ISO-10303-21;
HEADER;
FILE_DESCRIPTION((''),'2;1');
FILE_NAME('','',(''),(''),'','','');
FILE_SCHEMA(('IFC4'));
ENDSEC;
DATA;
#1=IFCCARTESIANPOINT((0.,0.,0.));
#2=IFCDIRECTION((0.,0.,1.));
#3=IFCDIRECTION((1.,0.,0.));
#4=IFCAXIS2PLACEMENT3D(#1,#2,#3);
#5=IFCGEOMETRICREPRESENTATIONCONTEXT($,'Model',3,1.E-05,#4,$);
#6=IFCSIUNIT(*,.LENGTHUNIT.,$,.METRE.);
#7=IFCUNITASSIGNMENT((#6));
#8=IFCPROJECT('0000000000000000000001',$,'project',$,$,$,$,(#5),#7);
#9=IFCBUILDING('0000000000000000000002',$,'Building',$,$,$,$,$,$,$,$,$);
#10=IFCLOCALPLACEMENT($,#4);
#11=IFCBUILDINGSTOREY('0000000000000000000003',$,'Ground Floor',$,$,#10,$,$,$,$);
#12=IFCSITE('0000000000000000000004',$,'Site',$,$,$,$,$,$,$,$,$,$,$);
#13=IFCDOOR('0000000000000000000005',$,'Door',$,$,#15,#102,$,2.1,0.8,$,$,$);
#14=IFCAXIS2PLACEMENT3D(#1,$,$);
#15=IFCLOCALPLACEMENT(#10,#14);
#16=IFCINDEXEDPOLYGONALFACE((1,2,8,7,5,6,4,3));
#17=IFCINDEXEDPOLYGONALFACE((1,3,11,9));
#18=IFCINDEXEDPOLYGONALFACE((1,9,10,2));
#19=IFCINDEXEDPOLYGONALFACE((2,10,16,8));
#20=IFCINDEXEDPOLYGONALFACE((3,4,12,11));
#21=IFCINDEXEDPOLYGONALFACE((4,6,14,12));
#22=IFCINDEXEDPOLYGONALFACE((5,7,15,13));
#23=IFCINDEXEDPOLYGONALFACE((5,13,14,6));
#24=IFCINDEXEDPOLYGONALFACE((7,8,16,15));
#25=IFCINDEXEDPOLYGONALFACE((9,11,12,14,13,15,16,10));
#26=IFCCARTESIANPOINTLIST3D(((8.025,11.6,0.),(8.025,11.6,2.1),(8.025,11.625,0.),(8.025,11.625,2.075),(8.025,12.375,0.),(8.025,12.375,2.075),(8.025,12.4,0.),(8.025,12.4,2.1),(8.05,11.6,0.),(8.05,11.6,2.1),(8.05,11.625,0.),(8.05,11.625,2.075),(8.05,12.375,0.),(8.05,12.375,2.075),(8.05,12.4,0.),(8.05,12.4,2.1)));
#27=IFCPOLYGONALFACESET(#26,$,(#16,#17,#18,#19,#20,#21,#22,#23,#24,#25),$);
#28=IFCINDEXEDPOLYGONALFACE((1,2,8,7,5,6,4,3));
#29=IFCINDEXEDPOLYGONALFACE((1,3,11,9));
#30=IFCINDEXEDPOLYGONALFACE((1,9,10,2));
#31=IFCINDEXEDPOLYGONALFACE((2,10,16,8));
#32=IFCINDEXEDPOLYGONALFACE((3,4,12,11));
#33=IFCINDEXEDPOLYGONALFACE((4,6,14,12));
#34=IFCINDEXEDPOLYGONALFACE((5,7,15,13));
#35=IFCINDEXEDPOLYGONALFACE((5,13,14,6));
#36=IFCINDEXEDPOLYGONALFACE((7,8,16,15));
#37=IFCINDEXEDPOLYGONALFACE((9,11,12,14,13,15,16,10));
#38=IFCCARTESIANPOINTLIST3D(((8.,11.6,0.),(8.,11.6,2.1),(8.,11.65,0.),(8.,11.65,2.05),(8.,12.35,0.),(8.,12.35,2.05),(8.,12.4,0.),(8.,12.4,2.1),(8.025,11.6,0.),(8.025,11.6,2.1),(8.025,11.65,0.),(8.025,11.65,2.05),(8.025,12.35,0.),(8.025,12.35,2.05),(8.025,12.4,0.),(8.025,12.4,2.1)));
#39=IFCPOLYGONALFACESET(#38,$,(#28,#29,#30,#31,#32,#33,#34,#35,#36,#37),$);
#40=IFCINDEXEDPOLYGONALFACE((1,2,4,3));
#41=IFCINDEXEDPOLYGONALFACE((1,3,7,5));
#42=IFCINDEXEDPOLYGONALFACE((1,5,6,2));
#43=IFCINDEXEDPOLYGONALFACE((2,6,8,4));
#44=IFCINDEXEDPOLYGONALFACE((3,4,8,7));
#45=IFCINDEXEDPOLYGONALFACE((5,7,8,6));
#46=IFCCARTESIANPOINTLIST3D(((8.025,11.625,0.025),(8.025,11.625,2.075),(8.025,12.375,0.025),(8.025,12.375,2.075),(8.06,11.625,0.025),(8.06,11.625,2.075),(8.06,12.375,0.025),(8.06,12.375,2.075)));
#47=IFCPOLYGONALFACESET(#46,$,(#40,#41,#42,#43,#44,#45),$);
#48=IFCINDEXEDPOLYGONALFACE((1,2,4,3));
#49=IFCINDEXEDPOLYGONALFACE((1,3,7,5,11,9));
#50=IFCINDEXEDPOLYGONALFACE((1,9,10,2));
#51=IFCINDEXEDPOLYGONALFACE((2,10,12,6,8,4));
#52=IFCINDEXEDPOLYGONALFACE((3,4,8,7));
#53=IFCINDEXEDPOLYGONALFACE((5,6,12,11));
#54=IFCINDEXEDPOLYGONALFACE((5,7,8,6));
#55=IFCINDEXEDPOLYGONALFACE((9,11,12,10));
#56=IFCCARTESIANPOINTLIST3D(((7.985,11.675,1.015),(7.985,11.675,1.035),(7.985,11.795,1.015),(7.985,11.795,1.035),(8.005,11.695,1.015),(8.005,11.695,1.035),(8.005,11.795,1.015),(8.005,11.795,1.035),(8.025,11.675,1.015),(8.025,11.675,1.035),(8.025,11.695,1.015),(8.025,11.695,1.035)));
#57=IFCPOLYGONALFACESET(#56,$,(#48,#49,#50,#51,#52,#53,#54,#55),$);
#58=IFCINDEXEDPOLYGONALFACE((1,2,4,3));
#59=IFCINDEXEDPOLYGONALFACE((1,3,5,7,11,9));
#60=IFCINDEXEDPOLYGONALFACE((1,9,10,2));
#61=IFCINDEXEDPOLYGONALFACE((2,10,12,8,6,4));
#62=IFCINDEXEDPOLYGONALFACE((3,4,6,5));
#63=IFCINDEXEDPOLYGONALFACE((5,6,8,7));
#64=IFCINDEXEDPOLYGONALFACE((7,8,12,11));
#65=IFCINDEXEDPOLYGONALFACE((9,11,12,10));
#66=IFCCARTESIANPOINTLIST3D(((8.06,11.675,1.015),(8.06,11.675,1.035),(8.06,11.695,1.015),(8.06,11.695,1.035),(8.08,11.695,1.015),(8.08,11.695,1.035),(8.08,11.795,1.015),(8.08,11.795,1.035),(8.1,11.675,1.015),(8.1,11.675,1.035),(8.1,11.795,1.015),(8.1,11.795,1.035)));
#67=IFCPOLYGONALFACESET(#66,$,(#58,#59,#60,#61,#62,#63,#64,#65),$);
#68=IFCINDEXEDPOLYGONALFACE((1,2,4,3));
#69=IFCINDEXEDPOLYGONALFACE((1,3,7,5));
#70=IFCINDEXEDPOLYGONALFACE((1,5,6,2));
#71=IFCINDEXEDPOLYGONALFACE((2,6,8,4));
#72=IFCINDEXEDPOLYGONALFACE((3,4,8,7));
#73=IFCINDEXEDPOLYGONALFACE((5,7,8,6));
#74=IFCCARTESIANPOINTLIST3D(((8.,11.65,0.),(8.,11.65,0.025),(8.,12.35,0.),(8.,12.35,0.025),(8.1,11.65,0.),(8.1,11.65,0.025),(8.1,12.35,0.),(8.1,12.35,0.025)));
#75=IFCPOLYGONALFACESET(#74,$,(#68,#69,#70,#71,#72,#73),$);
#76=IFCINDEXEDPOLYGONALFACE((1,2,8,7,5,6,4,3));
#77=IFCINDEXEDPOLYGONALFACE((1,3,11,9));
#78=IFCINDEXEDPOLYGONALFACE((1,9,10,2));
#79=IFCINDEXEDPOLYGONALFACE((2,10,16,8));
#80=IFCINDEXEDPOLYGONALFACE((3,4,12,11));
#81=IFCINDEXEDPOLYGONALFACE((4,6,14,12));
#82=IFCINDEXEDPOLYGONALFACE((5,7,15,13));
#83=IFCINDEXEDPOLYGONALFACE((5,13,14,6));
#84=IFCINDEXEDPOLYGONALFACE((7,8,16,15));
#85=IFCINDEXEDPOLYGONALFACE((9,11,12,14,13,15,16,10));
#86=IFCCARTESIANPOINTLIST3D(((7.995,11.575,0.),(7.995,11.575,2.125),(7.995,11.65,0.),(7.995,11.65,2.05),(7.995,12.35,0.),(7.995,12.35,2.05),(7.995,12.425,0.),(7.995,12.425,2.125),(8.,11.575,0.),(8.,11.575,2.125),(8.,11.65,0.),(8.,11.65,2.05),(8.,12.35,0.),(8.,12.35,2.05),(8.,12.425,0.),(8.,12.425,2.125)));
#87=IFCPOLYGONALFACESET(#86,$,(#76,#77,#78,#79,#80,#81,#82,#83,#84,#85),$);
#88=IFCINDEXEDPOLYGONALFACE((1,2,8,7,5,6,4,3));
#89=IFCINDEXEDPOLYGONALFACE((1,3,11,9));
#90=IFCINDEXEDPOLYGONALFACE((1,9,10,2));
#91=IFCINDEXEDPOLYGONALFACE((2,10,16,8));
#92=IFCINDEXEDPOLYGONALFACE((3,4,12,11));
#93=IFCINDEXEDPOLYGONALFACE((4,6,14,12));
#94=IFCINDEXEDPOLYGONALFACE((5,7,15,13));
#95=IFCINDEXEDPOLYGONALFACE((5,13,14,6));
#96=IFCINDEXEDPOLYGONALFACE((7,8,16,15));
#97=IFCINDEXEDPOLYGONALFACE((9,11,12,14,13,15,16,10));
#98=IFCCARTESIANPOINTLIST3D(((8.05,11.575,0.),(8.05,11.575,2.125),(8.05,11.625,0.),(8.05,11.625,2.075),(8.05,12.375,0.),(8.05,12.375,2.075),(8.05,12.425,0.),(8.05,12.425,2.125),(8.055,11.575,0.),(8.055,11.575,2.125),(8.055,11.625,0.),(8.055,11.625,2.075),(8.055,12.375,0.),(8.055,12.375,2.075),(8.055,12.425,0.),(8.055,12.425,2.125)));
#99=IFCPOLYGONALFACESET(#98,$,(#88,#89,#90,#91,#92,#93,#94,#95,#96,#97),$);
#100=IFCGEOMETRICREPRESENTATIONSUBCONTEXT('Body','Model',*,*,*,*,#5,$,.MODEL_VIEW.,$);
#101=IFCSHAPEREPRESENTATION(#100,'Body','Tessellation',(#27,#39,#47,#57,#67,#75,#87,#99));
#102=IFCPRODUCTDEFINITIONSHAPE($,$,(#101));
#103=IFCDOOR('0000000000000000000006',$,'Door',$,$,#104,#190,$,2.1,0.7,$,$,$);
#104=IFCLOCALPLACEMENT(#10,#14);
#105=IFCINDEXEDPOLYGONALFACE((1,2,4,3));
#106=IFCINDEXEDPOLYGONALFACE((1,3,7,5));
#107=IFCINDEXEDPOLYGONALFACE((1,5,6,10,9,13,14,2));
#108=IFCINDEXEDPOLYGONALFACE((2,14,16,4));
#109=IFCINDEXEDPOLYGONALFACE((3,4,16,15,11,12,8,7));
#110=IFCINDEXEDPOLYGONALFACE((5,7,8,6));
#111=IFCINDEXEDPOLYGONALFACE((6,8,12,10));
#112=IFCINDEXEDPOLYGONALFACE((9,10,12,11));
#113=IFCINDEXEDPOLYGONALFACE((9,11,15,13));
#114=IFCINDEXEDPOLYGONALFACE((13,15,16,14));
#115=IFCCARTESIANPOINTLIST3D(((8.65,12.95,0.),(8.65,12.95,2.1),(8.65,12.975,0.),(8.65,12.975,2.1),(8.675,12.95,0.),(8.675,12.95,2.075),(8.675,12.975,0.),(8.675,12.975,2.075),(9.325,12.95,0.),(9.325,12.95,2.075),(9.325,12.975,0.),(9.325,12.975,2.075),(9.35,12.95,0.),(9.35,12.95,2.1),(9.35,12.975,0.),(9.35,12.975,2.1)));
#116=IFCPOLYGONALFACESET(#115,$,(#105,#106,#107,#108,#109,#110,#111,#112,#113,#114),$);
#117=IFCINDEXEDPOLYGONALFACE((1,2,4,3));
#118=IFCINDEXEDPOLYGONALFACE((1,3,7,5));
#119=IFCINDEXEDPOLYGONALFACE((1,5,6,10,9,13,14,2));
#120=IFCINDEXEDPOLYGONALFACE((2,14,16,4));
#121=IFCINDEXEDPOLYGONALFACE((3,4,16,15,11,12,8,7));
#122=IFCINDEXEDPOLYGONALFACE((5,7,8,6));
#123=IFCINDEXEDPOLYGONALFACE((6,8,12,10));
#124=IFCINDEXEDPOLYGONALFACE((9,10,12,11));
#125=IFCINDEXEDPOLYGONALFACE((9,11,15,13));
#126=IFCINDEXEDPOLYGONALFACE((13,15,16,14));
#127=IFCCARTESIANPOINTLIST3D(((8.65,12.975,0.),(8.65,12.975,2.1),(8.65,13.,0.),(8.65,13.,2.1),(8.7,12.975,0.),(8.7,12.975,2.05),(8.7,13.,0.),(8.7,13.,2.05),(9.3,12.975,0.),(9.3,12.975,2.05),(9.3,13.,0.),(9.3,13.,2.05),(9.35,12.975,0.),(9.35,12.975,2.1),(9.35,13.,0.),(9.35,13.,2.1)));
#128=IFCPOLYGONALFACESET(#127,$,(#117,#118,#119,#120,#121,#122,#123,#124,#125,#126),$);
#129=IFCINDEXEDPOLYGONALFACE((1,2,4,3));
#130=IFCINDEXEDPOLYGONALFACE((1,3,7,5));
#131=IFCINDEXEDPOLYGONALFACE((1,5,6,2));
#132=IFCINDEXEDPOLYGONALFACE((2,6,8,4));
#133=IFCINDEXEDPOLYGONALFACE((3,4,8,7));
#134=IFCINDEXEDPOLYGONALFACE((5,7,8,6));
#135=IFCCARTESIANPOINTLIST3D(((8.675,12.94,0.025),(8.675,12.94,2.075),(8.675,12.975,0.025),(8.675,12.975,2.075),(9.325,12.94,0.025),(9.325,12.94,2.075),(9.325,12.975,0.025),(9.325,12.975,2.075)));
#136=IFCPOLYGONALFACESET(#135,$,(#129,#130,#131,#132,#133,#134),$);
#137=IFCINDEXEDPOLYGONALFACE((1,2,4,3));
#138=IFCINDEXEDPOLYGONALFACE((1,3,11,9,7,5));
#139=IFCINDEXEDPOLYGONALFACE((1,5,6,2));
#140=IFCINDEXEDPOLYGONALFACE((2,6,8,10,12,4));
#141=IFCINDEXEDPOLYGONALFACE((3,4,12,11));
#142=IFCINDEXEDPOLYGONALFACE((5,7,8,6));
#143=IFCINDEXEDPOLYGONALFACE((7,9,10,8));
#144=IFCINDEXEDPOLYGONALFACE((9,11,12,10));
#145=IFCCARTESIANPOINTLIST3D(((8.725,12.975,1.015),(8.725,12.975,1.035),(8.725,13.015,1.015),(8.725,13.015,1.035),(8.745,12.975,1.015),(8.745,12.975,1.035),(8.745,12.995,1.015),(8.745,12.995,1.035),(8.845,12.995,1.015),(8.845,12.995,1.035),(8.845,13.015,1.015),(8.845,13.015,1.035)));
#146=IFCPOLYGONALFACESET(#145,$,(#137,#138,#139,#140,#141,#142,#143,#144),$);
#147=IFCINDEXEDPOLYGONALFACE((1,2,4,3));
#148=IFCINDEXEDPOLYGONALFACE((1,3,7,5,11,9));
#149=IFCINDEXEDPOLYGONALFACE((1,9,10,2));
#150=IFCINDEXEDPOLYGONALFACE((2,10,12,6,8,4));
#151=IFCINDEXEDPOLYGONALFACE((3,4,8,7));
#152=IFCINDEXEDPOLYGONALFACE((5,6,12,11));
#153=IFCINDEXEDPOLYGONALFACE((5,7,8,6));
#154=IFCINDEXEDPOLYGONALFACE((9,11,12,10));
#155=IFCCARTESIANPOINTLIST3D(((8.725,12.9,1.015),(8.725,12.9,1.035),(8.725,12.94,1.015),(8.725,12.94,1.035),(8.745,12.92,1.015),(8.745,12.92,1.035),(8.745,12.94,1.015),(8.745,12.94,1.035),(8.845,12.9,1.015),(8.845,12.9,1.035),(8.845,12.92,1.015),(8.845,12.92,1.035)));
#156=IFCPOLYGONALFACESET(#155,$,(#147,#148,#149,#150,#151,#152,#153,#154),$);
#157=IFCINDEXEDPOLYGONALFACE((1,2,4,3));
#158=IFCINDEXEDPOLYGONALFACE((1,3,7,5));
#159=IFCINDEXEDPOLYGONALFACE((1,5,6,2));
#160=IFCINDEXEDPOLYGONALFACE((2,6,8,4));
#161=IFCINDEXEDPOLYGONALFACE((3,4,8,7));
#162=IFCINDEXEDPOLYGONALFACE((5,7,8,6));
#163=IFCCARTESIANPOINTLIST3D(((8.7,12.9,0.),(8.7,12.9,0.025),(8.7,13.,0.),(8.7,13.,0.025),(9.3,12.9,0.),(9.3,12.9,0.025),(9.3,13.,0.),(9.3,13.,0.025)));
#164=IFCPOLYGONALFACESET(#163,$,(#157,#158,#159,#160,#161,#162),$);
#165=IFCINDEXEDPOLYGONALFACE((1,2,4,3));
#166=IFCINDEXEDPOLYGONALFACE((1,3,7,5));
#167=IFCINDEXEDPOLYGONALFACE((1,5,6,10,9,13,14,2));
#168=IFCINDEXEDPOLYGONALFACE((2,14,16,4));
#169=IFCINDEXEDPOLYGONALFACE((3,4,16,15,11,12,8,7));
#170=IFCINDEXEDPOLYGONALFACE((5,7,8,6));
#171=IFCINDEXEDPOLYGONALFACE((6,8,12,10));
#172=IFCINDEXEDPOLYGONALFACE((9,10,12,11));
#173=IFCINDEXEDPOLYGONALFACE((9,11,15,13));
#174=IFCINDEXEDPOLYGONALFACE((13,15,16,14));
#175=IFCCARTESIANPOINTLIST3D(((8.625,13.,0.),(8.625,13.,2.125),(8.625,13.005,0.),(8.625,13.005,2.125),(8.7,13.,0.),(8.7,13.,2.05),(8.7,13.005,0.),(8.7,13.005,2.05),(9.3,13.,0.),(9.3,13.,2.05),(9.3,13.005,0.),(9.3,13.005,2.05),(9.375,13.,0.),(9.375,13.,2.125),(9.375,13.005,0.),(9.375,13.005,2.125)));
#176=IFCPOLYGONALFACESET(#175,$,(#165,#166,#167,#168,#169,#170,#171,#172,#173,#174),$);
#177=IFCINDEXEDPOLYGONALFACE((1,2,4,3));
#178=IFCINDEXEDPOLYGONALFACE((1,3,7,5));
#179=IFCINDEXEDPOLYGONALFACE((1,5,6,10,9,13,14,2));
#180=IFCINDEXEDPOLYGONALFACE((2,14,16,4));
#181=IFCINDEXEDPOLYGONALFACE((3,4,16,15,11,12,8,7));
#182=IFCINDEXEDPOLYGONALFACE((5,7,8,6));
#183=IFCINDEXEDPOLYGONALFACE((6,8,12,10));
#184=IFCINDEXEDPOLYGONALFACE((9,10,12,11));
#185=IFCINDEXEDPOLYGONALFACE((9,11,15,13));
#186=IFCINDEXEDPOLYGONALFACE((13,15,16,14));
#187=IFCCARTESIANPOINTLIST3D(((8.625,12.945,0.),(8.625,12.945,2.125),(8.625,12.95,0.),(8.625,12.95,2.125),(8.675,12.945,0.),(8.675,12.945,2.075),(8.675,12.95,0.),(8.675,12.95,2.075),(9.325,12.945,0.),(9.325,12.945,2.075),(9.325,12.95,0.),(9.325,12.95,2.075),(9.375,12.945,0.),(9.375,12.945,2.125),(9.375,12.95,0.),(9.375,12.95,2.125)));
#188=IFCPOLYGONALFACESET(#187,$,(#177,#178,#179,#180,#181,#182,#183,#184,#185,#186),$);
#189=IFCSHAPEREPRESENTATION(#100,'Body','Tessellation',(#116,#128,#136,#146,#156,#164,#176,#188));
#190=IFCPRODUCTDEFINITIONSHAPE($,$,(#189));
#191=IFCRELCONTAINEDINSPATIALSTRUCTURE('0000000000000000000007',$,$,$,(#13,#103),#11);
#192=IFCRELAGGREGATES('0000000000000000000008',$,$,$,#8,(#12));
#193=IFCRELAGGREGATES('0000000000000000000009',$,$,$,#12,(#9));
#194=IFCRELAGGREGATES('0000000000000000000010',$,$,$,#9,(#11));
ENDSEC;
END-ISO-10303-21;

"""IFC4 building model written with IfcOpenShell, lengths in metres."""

from ifc_helpers import new_model, si_unit, frame, origin_with_axes, place, context, subcontext, project, spatial, line, indexed_curve, outline, extrude, element, save


model = new_model("IFC4")

# Units and contexts
model_context = context("Model", 3, precision=1e-05, world=origin_with_axes())
body_context = subcontext(model_context, "Body", "Model", "MODEL_VIEW")
ifc_project = project(units=[si_unit("LENGTHUNIT", "METRE")], contexts=[model_context])

# Site, building, storey
site = spatial("IfcSite", under=ifc_project, Name="Site")
building = spatial("IfcBuilding", under=site, Name="Building")
storey_placement = place(None, origin_with_axes())
storey = spatial("IfcBuildingStorey", under=building, at=storey_placement, Name="Ground Floor")

# Doors
door_1_placement = place(storey_placement, frame((8.0, 12.4, 0.0), z_axis=(0.0, 0.0, 1.0), x_axis=(0.0, -1.0, 0.0)))
element("IfcDoor", 1, at=door_1_placement, inside=storey, Name="Door", OverallHeight=2.1, OverallWidth=0.8, context=body_context, shape_type="SweptSolid", body=[
    extrude(outline(indexed_curve([(0.0, 0.0), (0.0, 2.1), (0.8, 2.1), (0.8, 0.0), (0.775, 0.0), (0.775, 2.075), (0.025, 2.075), (0.025, 0.0)], segments=[line(1, 2, 3, 4, 5, 6, 7, 8, 1)])), frame((0.0, 0.025, 0.0), z_axis=(0.0, -1.0, 0.0), x_axis=(1.0, 0.0, 0.0)), (0.0, 0.0, -1.0), 0.025),
    extrude(outline(indexed_curve([(0.0, 0.0), (0.0, 2.1), (0.8, 2.1), (0.8, 0.0), (0.75, 0.0), (0.75, 2.05), (0.05, 2.05), (0.05, 0.0)], segments=[line(1, 2, 3, 4, 5, 6, 7, 8, 1)])), frame((0.0, 0.0, 0.0), z_axis=(0.0, -1.0, 0.0), x_axis=(1.0, 0.0, 0.0)), (0.0, 0.0, -1.0), 0.025),
    extrude(outline(indexed_curve([(0.0, 0.0), (0.75, 0.0), (0.75, 0.035), (0.0, 0.035)], segments=[line(1, 2, 3, 4, 1)])), frame((0.025, 0.025, 0.025), z_axis=(0.0, 0.0, 1.0), x_axis=(1.0, 0.0, 0.0)), (0.0, 0.0, 1.0), 2.05),
    extrude(outline(indexed_curve([(0.0, 0.0), (0.0, -0.04), (-0.12, -0.04), (-0.12, -0.02), (-0.02, -0.02), (-0.02, 0.0)], segments=[line(1, 2, 3, 4, 5, 6, 1)])), frame((0.725, 0.025, 1.015), z_axis=(0.0, 0.0, 1.0), x_axis=(1.0, 0.0, 0.0)), (0.0, 0.0, 1.0), 0.02),
    extrude(outline(indexed_curve([(0.0, 0.0), (0.0, 0.04), (-0.12, 0.04), (-0.12, 0.02), (-0.02, 0.02), (-0.02, 0.0)], segments=[line(1, 2, 3, 4, 5, 6, 1)])), frame((0.725, 0.06, 1.015), z_axis=(0.0, 0.0, 1.0), x_axis=(1.0, 0.0, 0.0)), (0.0, 0.0, 1.0), 0.02),
    extrude(outline(indexed_curve([(0.0, 0.0), (0.7, 0.0), (0.7, 0.1), (0.0, 0.1)], segments=[line(1, 2, 3, 4, 1)])), frame((0.05, 0.0, 0.0), z_axis=(0.0, 0.0, 1.0), x_axis=(1.0, 0.0, 0.0)), (0.0, 0.0, 1.0), 0.025),
    extrude(outline(indexed_curve([(0.0, 0.0), (0.0, 2.125), (0.85, 2.125), (0.85, 0.0), (0.775, 0.0), (0.775, 2.05), (0.075, 2.05), (0.075, 0.0)], segments=[line(1, 2, 3, 4, 5, 6, 7, 8, 1)])), frame((-0.025, -0.005, 0.0), z_axis=(0.0, -1.0, 0.0), x_axis=(1.0, 0.0, 0.0)), (0.0, 0.0, -1.0), 0.005),
    extrude(outline(indexed_curve([(0.0, 0.0), (0.0, 2.125), (0.85, 2.125), (0.85, 0.0), (0.8, 0.0), (0.8, 2.075), (0.05, 2.075), (0.05, 0.0)], segments=[line(1, 2, 3, 4, 5, 6, 7, 8, 1)])), frame((-0.025, 0.05, 0.0), z_axis=(0.0, -1.0, 0.0), x_axis=(1.0, 0.0, 0.0)), (0.0, 0.0, -1.0), 0.005),
])
door_2_placement = place(storey_placement, frame((9.35, 13.0, 0.0), z_axis=(0.0, 0.0, 1.0), x_axis=(-1.0, 0.0, 0.0)))
element("IfcDoor", 2, at=door_2_placement, inside=storey, Name="Door", OverallHeight=2.1, OverallWidth=0.7, context=body_context, shape_type="SweptSolid", body=[
    extrude(outline(indexed_curve([(0.0, 0.0), (0.0, 2.1), (0.7, 2.1), (0.7, 0.0), (0.675, 0.0), (0.675, 2.075), (0.025, 2.075), (0.025, 0.0)], segments=[line(1, 2, 3, 4, 5, 6, 7, 8, 1)])), frame((0.0, 0.025, 0.0), z_axis=(0.0, -1.0, 0.0), x_axis=(1.0, 0.0, 0.0)), (0.0, 0.0, -1.0), 0.025),
    extrude(outline(indexed_curve([(0.0, 0.0), (0.0, 2.1), (0.7, 2.1), (0.7, 0.0), (0.65, 0.0), (0.65, 2.05), (0.05, 2.05), (0.05, 0.0)], segments=[line(1, 2, 3, 4, 5, 6, 7, 8, 1)])), frame((0.0, 0.0, 0.0), z_axis=(0.0, -1.0, 0.0), x_axis=(1.0, 0.0, 0.0)), (0.0, 0.0, -1.0), 0.025),
    extrude(outline(indexed_curve([(0.0, 0.0), (0.65, 0.0), (0.65, 0.035), (0.0, 0.035)], segments=[line(1, 2, 3, 4, 1)])), frame((0.025, 0.025, 0.025), z_axis=(0.0, 0.0, 1.0), x_axis=(1.0, 0.0, 0.0)), (0.0, 0.0, 1.0), 2.05),
    extrude(outline(indexed_curve([(0.0, 0.0), (0.0, -0.04), (-0.12, -0.04), (-0.12, -0.02), (-0.02, -0.02), (-0.02, 0.0)], segments=[line(1, 2, 3, 4, 5, 6, 1)])), frame((0.625, 0.025, 1.015), z_axis=(0.0, 0.0, 1.0), x_axis=(1.0, 0.0, 0.0)), (0.0, 0.0, 1.0), 0.02),
    extrude(outline(indexed_curve([(0.0, 0.0), (0.0, 0.04), (-0.12, 0.04), (-0.12, 0.02), (-0.02, 0.02), (-0.02, 0.0)], segments=[line(1, 2, 3, 4, 5, 6, 1)])), frame((0.625, 0.06, 1.015), z_axis=(0.0, 0.0, 1.0), x_axis=(1.0, 0.0, 0.0)), (0.0, 0.0, 1.0), 0.02),
    extrude(outline(indexed_curve([(0.0, 0.0), (0.6, 0.0), (0.6, 0.1), (0.0, 0.1)], segments=[line(1, 2, 3, 4, 1)])), frame((0.05, 0.0, 0.0), z_axis=(0.0, 0.0, 1.0), x_axis=(1.0, 0.0, 0.0)), (0.0, 0.0, 1.0), 0.025),
    extrude(outline(indexed_curve([(0.0, 0.0), (0.0, 2.125), (0.75, 2.125), (0.75, 0.0), (0.675, 0.0), (0.675, 2.05), (0.075, 2.05), (0.075, 0.0)], segments=[line(1, 2, 3, 4, 5, 6, 7, 8, 1)])), frame((-0.025, -0.005, 0.0), z_axis=(0.0, -1.0, 0.0), x_axis=(1.0, 0.0, 0.0)), (0.0, 0.0, -1.0), 0.005),
    extrude(outline(indexed_curve([(0.0, 0.0), (0.0, 2.125), (0.75, 2.125), (0.75, 0.0), (0.7, 0.0), (0.7, 2.075), (0.05, 2.075), (0.05, 0.0)], segments=[line(1, 2, 3, 4, 5, 6, 7, 8, 1)])), frame((-0.025, 0.05, 0.0), z_axis=(0.0, -1.0, 0.0), x_axis=(1.0, 0.0, 0.0)), (0.0, 0.0, -1.0), 0.005),
])

save(model, "model.ifc")
